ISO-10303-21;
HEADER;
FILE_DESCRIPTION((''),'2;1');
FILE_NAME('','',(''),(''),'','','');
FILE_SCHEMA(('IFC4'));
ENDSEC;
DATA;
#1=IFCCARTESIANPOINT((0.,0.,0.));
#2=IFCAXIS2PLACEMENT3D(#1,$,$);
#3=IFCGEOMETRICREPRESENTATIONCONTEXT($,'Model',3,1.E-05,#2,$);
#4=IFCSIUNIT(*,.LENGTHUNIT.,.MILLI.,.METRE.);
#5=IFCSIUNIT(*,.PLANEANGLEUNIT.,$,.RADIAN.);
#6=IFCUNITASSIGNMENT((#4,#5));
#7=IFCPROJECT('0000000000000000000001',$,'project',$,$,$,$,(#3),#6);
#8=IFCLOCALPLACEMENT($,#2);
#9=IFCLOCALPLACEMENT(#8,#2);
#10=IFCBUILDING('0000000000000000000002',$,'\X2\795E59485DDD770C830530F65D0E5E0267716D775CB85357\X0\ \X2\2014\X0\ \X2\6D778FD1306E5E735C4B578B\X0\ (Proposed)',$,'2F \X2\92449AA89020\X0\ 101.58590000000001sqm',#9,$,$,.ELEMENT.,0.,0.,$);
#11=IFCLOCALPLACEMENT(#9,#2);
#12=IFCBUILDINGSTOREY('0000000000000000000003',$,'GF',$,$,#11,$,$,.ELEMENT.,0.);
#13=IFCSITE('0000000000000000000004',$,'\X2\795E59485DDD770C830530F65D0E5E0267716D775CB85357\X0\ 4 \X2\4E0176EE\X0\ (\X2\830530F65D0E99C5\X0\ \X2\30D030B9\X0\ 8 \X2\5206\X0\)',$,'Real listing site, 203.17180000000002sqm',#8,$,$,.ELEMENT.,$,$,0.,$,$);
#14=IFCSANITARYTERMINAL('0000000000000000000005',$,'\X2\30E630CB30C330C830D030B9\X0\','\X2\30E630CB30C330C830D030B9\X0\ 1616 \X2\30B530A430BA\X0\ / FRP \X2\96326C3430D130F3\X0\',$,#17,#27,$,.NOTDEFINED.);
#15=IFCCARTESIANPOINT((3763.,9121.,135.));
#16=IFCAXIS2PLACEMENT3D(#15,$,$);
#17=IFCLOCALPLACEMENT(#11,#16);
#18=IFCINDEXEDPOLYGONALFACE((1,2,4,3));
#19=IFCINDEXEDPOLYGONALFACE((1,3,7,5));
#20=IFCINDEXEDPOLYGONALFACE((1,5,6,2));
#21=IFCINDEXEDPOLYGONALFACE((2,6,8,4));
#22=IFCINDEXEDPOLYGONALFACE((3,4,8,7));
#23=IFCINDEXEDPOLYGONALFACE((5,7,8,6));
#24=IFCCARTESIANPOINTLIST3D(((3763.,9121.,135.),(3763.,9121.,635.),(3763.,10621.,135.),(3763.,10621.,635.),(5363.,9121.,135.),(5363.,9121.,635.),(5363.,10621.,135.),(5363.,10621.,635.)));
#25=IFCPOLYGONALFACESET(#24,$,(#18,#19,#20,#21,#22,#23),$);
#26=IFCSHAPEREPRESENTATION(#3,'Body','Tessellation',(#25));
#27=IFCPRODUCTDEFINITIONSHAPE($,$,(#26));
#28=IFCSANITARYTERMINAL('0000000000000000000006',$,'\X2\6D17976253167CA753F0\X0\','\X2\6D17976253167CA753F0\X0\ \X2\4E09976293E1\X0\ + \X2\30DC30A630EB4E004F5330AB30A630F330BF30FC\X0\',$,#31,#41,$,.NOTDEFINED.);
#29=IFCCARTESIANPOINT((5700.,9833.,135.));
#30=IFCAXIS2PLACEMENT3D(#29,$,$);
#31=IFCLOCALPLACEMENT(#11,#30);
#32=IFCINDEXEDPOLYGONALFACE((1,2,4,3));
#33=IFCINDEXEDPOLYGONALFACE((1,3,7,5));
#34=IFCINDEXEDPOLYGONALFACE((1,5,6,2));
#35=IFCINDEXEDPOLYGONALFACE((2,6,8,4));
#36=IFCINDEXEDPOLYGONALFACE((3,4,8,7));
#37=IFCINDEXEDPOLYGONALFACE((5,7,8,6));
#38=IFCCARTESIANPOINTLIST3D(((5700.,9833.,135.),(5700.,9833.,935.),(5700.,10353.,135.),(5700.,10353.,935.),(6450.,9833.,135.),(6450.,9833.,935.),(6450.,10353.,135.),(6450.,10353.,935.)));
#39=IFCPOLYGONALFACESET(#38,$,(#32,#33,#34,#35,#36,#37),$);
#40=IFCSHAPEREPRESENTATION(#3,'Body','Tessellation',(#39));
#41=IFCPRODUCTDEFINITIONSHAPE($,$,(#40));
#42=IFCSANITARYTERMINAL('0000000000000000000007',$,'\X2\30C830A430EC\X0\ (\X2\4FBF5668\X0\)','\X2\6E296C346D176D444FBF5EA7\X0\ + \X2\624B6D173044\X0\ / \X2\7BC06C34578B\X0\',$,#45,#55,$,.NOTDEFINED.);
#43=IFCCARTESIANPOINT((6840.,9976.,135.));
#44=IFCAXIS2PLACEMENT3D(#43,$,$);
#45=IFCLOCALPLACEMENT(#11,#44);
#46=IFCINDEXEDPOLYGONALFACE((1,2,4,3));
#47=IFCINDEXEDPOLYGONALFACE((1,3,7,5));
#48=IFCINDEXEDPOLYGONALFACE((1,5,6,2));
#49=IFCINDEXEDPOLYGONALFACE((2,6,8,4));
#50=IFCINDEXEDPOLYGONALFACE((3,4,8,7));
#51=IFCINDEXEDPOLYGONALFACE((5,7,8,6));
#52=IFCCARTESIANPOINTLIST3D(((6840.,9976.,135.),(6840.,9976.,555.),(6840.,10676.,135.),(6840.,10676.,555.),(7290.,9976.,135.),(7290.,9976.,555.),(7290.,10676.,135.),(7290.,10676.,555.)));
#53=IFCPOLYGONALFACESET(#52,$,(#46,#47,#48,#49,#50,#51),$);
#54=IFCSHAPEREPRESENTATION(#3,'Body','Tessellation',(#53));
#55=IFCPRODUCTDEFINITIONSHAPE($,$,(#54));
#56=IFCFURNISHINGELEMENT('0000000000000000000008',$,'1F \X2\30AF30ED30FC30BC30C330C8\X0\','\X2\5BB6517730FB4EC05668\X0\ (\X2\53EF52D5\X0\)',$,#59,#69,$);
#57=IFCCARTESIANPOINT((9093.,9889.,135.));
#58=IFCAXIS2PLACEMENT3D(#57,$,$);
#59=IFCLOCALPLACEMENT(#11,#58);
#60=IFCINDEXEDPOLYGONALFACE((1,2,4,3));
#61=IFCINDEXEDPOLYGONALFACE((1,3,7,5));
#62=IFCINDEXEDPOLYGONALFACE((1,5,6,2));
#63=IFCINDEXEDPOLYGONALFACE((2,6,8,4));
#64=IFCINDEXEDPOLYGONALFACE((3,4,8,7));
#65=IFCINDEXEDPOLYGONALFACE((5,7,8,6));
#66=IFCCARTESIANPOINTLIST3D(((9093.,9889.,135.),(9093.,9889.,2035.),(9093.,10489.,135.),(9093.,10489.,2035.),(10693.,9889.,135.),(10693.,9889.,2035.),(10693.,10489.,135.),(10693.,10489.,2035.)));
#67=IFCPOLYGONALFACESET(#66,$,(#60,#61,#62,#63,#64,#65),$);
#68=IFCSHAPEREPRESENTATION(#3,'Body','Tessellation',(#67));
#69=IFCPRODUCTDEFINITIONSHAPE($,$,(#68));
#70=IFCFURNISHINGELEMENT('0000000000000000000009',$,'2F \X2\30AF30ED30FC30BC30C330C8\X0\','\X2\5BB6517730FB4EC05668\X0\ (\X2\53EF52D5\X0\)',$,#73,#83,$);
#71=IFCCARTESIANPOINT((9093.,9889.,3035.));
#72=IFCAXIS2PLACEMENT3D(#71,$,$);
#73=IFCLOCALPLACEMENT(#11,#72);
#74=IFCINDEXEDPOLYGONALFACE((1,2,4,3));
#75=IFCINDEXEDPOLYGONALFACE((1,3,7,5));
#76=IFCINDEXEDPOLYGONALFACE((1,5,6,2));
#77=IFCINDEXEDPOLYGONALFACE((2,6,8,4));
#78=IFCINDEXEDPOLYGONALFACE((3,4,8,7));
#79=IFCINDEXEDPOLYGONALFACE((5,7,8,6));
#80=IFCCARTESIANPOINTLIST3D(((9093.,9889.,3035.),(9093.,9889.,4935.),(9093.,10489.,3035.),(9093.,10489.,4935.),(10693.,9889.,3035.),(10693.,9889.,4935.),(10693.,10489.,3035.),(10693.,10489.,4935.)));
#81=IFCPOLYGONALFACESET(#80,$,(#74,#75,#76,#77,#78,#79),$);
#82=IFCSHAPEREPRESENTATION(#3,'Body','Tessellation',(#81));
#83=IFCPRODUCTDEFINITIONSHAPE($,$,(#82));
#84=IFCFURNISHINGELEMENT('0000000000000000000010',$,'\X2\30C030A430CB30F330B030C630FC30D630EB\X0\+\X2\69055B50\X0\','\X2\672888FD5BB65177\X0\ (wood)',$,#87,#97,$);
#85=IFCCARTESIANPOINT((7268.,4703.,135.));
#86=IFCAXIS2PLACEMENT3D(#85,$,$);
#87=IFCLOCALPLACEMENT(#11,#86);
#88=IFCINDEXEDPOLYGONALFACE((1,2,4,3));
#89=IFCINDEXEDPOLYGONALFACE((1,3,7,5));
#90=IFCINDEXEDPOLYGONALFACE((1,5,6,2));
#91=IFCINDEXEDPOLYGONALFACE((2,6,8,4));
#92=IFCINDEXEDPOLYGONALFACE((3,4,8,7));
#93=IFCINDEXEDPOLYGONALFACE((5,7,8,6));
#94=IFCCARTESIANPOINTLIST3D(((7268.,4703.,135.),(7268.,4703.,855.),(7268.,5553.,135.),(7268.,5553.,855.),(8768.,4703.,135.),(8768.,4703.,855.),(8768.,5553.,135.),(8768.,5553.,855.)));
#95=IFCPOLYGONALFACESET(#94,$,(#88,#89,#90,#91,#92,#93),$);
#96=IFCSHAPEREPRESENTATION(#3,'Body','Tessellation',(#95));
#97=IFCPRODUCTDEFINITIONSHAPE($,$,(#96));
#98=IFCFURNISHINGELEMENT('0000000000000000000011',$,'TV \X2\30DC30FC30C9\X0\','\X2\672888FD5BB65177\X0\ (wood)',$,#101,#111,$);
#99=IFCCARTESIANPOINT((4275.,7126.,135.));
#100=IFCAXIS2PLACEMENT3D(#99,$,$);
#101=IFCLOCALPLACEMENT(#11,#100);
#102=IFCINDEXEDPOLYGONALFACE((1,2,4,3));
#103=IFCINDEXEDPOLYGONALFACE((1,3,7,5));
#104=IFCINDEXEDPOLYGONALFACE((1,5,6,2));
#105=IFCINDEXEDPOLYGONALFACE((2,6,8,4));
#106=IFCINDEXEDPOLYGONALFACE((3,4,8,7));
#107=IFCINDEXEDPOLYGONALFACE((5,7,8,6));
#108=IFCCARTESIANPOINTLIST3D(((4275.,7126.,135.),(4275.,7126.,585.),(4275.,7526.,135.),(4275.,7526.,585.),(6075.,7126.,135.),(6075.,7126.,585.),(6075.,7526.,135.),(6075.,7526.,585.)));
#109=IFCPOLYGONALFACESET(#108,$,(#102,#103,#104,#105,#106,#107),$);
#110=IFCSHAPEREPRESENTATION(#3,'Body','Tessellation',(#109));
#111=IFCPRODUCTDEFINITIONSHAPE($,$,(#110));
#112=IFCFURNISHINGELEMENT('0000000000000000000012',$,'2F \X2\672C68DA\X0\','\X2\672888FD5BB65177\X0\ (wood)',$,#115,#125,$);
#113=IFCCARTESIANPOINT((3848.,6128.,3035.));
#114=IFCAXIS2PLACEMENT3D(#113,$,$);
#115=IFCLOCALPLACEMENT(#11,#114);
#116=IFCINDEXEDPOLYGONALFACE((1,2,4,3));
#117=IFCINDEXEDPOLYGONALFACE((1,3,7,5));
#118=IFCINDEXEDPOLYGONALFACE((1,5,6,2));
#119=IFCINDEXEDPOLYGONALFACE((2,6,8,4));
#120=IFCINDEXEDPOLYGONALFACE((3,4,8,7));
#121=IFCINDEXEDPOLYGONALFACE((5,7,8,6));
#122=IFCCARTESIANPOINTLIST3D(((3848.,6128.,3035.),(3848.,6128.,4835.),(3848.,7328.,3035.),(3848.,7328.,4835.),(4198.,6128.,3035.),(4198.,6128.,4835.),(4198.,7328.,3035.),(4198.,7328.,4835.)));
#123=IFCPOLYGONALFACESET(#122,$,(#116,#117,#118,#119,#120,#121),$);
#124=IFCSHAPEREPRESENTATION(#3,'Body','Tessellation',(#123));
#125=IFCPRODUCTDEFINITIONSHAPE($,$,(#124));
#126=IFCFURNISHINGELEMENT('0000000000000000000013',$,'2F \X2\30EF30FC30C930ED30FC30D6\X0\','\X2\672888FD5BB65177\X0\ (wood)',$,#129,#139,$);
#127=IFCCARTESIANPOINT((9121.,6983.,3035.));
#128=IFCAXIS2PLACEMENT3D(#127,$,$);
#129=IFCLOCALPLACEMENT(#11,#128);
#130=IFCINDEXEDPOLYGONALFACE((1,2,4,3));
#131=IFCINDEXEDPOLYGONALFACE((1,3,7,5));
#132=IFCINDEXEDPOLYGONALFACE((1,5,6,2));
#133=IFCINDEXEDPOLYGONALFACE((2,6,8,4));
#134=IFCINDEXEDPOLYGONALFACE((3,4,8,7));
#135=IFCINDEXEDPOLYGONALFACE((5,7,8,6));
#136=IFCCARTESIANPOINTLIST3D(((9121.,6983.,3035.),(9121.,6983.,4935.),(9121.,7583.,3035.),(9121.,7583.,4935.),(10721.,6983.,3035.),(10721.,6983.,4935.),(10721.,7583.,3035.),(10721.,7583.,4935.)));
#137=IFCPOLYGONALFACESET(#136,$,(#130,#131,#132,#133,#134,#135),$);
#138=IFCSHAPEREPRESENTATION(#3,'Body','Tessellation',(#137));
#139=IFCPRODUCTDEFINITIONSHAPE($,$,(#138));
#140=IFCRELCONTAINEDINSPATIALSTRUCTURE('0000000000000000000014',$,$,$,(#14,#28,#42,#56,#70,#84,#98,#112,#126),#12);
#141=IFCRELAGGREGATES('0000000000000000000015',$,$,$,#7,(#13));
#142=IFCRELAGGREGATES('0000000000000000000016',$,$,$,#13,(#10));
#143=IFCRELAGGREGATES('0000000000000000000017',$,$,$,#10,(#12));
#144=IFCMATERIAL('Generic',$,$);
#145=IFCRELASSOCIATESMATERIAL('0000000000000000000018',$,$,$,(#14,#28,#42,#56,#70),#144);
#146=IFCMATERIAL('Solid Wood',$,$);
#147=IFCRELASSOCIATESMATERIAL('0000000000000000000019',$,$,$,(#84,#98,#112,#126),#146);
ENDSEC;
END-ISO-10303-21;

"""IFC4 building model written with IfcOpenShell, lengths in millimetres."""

from ifc_helpers import new_model, si_unit, frame, frame_2d, origin, place, context, project, spatial, rectangle, extrude, material, element, save


model = new_model("IFC4")

# Units and contexts
model_context = context("Model", 3, precision=1e-05, world=origin())
ifc_project = project(units=[si_unit("LENGTHUNIT", "METRE", prefix="MILLI"), si_unit("PLANEANGLEUNIT", "RADIAN")], contexts=[model_context])

# Site, building, storey
site_placement = place(None, origin())
site = spatial("IfcSite", under=ifc_project, at=site_placement, Name="神奈川県茅ヶ崎市東海岸南 4 丁目 (茅ヶ崎駅 バス 8 分)", ObjectType="Real listing site, 203.17180000000002sqm", CompositionType="ELEMENT", RefElevation=0.0)
building_placement = place(site_placement, origin())
building = spatial("IfcBuilding", under=site, at=building_placement, Name="神奈川県茅ヶ崎市東海岸南 — 海近の平屋型 (Proposed)", ObjectType="2F 鉄骨造 101.58590000000001sqm", CompositionType="ELEMENT", ElevationOfRefHeight=0.0, ElevationOfTerrain=0.0)
storey_placement = place(building_placement, origin())
storey = spatial("IfcBuildingStorey", under=building, at=storey_placement, Name="GF", CompositionType="ELEMENT", Elevation=0.0)

# Shared definitions
ifc_material_1 = material(Name="Solid Wood")

# Sanitary terminals
ifc_material_2 = material(Name="Generic")
sanitary_terminal_1_placement = place(storey_placement, frame((3763.0, 9121.0, 135.0)))
element("IfcSanitaryTerminal", 1, at=sanitary_terminal_1_placement, inside=storey, material=ifc_material_2, Name="ユニットバス", Description="ユニットバス 1616 サイズ / FRP 防水パン", PredefinedType="NOTDEFINED", context=model_context, shape_type="SweptSolid", body=[
    extrude(rectangle(XDim=1600.0, YDim=1500.0, at=frame_2d((800.0, 750.0))), frame((3763.0, 9121.0, 135.0)), (0.0, 0.0, 1.0), 500.0),
])
sanitary_terminal_2_placement = place(storey_placement, frame((5700.0, 9833.0, 135.0)))
element("IfcSanitaryTerminal", 2, at=sanitary_terminal_2_placement, inside=storey, material=ifc_material_2, Name="洗面化粧台", Description="洗面化粧台 三面鏡 + ボウル一体カウンター", PredefinedType="NOTDEFINED", context=model_context, shape_type="SweptSolid", body=[
    extrude(rectangle(XDim=750.0, YDim=520.0, at=frame_2d((375.0, 260.0))), frame((5700.0, 9833.0, 135.0)), (0.0, 0.0, 1.0), 800.0),
])
sanitary_terminal_3_placement = place(storey_placement, frame((6840.0, 9976.0, 135.0)))
element("IfcSanitaryTerminal", 3, at=sanitary_terminal_3_placement, inside=storey, material=ifc_material_2, Name="トイレ (便器)", Description="温水洗浄便座 + 手洗い / 節水型", PredefinedType="NOTDEFINED", context=model_context, shape_type="SweptSolid", body=[
    extrude(rectangle(XDim=450.0, YDim=700.0, at=frame_2d((225.0, 350.0))), frame((6840.0, 9976.0, 135.0)), (0.0, 0.0, 1.0), 420.0),
])

# Furnishing elements
furnishing_1_placement = place(storey_placement, frame((9093.0, 9889.0, 135.0)))
element("IfcFurnishingElement", 4, at=furnishing_1_placement, inside=storey, material=ifc_material_2, Name="1F クローゼット", Description="家具・什器 (可動)", context=model_context, shape_type="SweptSolid", body=[
    extrude(rectangle(XDim=1600.0, YDim=600.0, at=frame_2d((800.0, 300.0))), frame((9093.0, 9889.0, 135.0)), (0.0, 0.0, 1.0), 1900.0),
])
furnishing_2_placement = place(storey_placement, frame((9093.0, 9889.0, 3035.0)))
element("IfcFurnishingElement", 5, at=furnishing_2_placement, inside=storey, material=ifc_material_2, Name="2F クローゼット", Description="家具・什器 (可動)", context=model_context, shape_type="SweptSolid", body=[
    extrude(rectangle(XDim=1600.0, YDim=600.0, at=frame_2d((800.0, 300.0))), frame((9093.0, 9889.0, 3035.0)), (0.0, 0.0, 1.0), 1900.0),
])
furnishing_3_placement = place(storey_placement, frame((7268.0, 4703.0, 135.0)))
element("IfcFurnishingElement", 6, at=furnishing_3_placement, inside=storey, material=ifc_material_1, Name="ダイニングテーブル+椅子", Description="木製家具 (wood)", context=model_context, shape_type="SweptSolid", body=[
    extrude(rectangle(XDim=1500.0, YDim=850.0, at=frame_2d((750.0, 425.0))), frame((7268.0, 4703.0, 135.0)), (0.0, 0.0, 1.0), 720.0),
])
furnishing_4_placement = place(storey_placement, frame((4275.0, 7126.0, 135.0)))
element("IfcFurnishingElement", 7, at=furnishing_4_placement, inside=storey, material=ifc_material_1, Name="TV ボード", Description="木製家具 (wood)", context=model_context, shape_type="SweptSolid", body=[
    extrude(rectangle(XDim=1800.0, YDim=400.0, at=frame_2d((900.0, 200.0))), frame((4275.0, 7126.0, 135.0)), (0.0, 0.0, 1.0), 450.0),
])
furnishing_5_placement = place(storey_placement, frame((3848.0, 6128.0, 3035.0)))
element("IfcFurnishingElement", 8, at=furnishing_5_placement, inside=storey, material=ifc_material_1, Name="2F 本棚", Description="木製家具 (wood)", context=model_context, shape_type="SweptSolid", body=[
    extrude(rectangle(XDim=350.0, YDim=1200.0, at=frame_2d((175.0, 600.0))), frame((3848.0, 6128.0, 3035.0)), (0.0, 0.0, 1.0), 1800.0),
])
furnishing_6_placement = place(storey_placement, frame((9121.0, 6983.0, 3035.0)))
element("IfcFurnishingElement", 9, at=furnishing_6_placement, inside=storey, material=ifc_material_1, Name="2F ワードローブ", Description="木製家具 (wood)", context=model_context, shape_type="SweptSolid", body=[
    extrude(rectangle(XDim=1600.0, YDim=600.0, at=frame_2d((800.0, 300.0))), frame((9121.0, 6983.0, 3035.0)), (0.0, 0.0, 1.0), 1900.0),
])

save(model, "model.ifc")
